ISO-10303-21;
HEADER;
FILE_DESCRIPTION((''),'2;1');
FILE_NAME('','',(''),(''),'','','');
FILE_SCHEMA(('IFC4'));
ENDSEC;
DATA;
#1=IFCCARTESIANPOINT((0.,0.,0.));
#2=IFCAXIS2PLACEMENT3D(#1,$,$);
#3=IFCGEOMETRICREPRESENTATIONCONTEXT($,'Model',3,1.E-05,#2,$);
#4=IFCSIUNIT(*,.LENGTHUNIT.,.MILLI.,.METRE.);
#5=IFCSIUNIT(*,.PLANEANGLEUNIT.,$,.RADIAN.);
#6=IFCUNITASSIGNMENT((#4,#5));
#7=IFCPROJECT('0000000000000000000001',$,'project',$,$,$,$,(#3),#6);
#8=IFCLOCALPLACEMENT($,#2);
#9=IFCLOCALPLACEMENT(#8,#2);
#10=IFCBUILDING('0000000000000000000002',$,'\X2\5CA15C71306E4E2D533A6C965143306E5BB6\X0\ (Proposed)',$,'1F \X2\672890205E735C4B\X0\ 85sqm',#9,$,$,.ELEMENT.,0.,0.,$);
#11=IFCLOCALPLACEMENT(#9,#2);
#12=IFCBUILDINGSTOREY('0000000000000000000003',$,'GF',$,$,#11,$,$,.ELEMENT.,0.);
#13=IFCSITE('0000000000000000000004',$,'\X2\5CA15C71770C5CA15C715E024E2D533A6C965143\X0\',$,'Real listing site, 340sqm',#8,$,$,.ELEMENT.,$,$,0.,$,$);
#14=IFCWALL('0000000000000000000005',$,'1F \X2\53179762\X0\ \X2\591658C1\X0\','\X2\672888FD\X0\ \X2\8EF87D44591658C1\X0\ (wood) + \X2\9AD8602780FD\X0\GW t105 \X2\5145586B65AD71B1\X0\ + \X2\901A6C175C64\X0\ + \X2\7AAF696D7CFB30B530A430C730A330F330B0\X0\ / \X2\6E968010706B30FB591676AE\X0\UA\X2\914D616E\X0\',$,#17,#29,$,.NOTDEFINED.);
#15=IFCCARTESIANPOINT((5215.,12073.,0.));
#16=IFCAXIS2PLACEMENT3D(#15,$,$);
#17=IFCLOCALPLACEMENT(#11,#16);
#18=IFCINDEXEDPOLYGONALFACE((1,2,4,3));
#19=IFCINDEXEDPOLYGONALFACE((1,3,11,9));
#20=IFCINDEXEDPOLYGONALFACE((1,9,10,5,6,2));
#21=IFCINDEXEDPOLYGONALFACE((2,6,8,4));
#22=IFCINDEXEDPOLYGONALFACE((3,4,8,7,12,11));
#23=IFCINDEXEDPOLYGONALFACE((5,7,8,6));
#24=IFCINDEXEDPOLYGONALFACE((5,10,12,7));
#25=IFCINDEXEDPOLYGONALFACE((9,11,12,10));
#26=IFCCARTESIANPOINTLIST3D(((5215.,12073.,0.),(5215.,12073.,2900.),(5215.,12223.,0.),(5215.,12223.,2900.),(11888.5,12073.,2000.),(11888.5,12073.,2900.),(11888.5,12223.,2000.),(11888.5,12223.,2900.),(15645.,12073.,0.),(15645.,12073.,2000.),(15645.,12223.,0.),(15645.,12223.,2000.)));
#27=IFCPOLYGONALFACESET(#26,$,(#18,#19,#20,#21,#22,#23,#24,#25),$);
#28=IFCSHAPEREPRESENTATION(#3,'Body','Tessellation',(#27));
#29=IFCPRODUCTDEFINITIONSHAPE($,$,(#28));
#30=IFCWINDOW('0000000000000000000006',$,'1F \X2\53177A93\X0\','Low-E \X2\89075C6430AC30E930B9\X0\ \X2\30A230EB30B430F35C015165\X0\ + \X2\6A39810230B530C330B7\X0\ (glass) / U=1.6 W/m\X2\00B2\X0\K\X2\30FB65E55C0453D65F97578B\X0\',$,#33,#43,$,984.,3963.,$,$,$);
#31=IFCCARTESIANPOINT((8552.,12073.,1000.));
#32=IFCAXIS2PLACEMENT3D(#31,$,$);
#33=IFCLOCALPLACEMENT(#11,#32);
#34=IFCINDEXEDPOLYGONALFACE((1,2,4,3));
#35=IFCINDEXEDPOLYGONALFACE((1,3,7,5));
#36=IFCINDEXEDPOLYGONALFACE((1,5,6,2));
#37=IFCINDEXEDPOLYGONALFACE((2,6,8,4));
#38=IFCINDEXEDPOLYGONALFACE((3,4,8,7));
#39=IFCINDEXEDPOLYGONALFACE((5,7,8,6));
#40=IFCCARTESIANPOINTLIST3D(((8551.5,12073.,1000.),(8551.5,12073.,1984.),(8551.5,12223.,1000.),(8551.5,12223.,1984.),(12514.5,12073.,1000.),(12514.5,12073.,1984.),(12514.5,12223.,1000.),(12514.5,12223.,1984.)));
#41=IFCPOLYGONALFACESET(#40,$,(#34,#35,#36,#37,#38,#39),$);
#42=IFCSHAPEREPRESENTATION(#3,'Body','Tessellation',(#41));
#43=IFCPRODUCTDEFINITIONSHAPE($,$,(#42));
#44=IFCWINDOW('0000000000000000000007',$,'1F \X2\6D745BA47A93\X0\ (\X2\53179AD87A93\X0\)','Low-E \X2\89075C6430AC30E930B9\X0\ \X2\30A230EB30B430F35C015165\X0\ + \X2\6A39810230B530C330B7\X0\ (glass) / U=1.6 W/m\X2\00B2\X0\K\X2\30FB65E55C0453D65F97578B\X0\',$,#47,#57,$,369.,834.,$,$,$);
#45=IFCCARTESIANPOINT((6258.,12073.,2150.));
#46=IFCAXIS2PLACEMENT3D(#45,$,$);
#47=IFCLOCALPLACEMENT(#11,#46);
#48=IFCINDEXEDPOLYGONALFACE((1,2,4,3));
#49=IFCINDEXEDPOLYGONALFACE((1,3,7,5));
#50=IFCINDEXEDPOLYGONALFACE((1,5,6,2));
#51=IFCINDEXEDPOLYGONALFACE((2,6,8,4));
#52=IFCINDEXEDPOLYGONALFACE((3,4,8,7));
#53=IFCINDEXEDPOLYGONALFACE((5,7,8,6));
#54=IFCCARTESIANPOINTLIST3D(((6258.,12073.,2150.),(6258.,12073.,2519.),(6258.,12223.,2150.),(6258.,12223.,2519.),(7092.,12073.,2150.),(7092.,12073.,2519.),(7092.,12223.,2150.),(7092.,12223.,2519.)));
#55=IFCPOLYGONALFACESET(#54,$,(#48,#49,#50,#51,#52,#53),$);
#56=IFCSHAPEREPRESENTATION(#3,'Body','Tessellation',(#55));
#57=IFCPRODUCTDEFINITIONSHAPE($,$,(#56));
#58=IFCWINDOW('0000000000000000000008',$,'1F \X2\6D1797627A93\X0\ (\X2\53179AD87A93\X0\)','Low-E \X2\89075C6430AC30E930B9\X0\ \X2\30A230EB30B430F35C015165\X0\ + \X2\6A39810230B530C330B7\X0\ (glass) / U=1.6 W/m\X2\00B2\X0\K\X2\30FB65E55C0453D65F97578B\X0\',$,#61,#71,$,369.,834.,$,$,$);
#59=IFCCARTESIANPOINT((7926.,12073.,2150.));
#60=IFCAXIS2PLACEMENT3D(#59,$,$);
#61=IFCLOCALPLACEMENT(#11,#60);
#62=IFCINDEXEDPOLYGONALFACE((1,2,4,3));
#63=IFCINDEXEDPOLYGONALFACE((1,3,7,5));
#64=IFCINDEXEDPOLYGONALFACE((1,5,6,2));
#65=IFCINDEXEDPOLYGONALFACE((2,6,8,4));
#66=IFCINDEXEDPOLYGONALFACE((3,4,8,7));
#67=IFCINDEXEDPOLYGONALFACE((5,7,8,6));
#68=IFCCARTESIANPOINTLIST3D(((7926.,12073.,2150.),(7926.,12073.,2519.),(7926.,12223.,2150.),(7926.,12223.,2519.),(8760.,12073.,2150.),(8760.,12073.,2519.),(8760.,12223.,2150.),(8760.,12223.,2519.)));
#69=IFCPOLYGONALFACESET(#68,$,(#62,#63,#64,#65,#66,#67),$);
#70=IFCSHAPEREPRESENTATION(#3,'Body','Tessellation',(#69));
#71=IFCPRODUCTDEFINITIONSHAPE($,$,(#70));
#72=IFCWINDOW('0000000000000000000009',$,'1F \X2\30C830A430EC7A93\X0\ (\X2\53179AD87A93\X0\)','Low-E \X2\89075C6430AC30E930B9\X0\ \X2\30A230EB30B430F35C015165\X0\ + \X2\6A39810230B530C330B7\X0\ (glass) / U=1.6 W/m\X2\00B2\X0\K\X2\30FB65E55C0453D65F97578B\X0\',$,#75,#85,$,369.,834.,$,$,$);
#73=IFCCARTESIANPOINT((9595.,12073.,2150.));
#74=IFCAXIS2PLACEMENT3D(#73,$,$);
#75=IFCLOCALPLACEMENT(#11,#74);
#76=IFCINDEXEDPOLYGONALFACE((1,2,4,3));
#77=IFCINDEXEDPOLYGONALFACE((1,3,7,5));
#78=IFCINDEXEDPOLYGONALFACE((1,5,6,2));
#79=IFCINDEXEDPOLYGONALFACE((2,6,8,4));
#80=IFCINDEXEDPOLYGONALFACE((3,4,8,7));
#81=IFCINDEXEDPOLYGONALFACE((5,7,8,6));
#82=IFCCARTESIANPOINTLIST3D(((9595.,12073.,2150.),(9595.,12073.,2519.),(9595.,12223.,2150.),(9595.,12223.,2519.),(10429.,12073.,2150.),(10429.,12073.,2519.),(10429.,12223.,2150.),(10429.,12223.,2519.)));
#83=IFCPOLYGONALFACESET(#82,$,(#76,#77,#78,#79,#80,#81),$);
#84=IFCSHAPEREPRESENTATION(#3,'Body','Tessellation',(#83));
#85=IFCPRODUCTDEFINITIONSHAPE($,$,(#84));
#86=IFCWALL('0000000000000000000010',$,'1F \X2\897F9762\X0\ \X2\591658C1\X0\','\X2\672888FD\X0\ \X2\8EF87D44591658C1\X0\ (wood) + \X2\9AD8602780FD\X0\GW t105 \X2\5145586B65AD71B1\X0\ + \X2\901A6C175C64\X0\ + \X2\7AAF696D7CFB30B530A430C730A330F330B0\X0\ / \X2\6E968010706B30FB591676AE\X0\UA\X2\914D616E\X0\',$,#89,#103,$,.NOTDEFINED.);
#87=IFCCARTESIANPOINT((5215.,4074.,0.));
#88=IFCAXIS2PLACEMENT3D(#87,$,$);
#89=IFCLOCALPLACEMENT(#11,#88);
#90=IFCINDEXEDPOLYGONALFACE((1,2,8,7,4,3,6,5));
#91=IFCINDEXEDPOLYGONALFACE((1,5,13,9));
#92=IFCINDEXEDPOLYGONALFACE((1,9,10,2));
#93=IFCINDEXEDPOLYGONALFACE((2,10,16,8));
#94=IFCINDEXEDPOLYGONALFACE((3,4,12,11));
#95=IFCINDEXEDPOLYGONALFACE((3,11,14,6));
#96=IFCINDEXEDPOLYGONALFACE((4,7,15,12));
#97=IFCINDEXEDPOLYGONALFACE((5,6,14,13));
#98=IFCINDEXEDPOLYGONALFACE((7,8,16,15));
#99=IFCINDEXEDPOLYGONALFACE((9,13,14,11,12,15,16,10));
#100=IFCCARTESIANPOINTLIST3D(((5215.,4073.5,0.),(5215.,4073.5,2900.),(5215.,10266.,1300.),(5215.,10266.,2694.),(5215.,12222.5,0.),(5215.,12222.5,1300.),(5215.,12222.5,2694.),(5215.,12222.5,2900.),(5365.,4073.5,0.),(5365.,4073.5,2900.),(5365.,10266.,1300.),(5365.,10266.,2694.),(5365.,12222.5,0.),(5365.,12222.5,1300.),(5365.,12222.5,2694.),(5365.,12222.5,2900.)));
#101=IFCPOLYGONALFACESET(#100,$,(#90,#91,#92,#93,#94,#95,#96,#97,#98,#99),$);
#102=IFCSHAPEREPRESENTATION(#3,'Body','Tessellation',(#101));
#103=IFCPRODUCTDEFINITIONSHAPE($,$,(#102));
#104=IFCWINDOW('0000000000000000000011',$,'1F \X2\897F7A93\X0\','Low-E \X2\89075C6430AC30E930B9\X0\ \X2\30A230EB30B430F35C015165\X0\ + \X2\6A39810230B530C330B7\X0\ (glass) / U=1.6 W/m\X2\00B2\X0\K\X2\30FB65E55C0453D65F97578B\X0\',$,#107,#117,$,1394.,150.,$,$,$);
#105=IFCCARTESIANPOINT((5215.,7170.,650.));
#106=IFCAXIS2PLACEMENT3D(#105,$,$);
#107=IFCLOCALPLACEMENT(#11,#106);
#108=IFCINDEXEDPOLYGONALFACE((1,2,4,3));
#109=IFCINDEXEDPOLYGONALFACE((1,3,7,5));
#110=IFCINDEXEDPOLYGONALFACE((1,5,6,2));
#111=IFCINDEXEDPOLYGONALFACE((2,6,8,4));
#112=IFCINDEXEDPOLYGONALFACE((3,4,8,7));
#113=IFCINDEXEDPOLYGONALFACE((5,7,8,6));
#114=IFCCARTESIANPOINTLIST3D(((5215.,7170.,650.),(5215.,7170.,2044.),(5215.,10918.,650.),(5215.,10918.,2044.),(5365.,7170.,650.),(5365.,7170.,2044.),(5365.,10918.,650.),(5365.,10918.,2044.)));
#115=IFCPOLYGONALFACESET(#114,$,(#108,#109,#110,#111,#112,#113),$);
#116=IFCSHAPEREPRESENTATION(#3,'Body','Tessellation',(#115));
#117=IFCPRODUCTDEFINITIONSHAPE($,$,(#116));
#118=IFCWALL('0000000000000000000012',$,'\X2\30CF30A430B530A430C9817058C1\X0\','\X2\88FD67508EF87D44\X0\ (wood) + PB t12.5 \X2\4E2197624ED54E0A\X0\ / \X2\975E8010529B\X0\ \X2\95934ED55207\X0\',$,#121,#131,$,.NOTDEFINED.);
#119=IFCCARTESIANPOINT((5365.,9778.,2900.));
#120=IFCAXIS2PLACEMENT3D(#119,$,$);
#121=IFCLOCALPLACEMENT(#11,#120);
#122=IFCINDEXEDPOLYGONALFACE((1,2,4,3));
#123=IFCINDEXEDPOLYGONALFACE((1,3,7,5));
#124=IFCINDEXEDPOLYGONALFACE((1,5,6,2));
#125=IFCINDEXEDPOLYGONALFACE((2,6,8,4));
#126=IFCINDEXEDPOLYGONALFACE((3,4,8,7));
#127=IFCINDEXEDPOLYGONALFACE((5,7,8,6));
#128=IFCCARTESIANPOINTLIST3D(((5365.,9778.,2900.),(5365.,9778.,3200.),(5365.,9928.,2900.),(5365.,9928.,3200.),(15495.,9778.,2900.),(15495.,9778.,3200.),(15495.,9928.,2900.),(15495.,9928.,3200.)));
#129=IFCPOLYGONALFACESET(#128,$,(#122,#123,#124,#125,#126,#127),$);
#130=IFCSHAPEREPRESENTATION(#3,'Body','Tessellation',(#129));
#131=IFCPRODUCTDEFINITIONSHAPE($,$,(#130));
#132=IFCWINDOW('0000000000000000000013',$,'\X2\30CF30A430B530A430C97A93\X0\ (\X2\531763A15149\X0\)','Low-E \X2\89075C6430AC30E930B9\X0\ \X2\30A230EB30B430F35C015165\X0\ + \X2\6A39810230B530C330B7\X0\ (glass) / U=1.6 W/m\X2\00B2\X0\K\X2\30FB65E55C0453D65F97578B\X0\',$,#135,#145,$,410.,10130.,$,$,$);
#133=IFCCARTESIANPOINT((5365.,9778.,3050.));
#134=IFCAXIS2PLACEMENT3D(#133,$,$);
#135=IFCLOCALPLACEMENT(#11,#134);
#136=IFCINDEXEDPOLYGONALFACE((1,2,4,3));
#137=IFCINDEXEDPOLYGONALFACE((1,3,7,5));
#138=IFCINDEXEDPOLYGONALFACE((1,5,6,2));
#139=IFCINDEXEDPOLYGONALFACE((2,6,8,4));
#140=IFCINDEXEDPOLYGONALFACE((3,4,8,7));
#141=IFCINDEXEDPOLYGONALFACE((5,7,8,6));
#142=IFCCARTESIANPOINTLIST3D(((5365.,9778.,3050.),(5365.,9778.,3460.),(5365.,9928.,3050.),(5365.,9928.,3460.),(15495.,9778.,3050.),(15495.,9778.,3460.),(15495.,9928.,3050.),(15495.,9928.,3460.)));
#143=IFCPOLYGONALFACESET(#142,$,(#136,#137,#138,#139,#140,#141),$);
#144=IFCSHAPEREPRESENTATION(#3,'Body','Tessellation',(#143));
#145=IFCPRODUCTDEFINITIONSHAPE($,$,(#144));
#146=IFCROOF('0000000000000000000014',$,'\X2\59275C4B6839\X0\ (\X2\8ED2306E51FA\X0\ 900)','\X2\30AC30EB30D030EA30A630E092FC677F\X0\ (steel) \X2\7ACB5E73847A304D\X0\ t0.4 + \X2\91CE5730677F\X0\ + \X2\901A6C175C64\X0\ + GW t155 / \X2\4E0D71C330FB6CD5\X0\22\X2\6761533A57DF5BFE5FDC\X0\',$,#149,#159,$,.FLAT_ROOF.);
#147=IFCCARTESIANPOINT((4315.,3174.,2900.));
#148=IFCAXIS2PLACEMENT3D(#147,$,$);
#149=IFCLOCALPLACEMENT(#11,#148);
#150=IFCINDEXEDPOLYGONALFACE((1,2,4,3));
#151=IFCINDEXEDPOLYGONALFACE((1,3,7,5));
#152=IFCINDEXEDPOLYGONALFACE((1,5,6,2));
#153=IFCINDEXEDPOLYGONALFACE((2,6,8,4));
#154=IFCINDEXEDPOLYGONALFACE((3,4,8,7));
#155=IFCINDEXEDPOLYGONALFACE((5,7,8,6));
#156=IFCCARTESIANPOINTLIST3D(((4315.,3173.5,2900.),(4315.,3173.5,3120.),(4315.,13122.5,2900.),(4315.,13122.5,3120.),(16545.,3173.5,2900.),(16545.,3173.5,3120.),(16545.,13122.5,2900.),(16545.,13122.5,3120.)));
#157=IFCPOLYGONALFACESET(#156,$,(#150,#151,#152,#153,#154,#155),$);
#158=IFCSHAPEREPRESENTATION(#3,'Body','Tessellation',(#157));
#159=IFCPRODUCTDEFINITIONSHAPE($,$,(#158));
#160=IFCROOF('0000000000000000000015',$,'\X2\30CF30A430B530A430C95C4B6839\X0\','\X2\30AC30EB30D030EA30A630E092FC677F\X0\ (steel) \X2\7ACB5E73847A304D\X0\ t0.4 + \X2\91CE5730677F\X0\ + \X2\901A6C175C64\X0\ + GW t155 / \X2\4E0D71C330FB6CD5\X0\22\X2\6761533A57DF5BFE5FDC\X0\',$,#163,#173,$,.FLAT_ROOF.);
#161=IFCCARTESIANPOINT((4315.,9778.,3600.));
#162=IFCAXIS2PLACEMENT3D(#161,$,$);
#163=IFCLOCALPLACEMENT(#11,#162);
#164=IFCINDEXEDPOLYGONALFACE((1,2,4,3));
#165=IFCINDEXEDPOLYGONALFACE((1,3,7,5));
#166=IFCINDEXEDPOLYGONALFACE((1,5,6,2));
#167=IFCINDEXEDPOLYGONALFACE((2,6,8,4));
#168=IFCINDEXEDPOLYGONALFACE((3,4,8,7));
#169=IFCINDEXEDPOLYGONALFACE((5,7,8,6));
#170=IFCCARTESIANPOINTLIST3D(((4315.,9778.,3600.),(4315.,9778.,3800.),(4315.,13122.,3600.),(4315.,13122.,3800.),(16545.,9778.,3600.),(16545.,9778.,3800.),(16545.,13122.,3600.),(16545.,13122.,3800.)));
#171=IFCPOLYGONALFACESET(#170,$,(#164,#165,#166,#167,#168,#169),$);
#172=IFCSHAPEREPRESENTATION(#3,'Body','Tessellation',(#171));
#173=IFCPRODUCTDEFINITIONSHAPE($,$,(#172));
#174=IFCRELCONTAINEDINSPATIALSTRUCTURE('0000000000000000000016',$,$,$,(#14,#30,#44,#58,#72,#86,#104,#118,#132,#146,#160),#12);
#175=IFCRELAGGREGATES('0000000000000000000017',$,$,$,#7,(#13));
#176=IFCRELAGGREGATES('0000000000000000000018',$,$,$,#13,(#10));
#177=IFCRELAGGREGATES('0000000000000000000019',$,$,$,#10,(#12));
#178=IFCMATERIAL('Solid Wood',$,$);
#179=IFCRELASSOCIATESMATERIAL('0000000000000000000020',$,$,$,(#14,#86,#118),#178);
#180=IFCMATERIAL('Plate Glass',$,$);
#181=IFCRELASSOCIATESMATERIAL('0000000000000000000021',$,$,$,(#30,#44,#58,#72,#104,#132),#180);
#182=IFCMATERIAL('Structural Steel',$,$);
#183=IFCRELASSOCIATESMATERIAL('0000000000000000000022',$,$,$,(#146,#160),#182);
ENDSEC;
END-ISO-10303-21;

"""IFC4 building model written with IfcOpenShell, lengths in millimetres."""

from ifc_helpers import new_model, si_unit, frame, frame_2d, origin, place, context, project, spatial, rectangle, extrude, material, element, fill, save


model = new_model("IFC4")

# Units and contexts
model_context = context("Model", 3, precision=1e-05, world=origin())
ifc_project = project(units=[si_unit("LENGTHUNIT", "METRE", prefix="MILLI"), si_unit("PLANEANGLEUNIT", "RADIAN")], contexts=[model_context])

# Site, building, storey
site_placement = place(None, origin())
site = spatial("IfcSite", under=ifc_project, at=site_placement, Name="岡山県岡山市中区沖元", ObjectType="Real listing site, 340sqm", CompositionType="ELEMENT", RefElevation=0.0)
building_placement = place(site_placement, origin())
building = spatial("IfcBuilding", under=site, at=building_placement, Name="岡山の中区沖元の家 (Proposed)", ObjectType="1F 木造平屋 85sqm", CompositionType="ELEMENT", ElevationOfRefHeight=0.0, ElevationOfTerrain=0.0)
storey_placement = place(building_placement, origin())
storey = spatial("IfcBuildingStorey", under=building, at=storey_placement, Name="GF", CompositionType="ELEMENT", Elevation=0.0)

# Shared definitions
ifc_material_1 = material(Name="Solid Wood")

# Shared definitions
ifc_material_2 = material(Name="Plate Glass")

# Wall, openings, windows
wall_1_placement = place(storey_placement, frame((5215.0, 12073.0, 0.0)))
wall_1 = element("IfcWall", 1, at=wall_1_placement, inside=storey, material=ifc_material_1, Name="1F 北面 外壁", Description="木製 軸組外壁 (wood) + 高性能GW t105 充填断熱 + 通気層 + 窯業系サイディング / 準耐火・外皮UA配慮", PredefinedType="NOTDEFINED", context=model_context, shape_type="SweptSolid", body=[
    extrude(rectangle(XDim=10430.0, YDim=150.0, at=frame_2d((5215.0, 75.0))), frame((5215.0, 12073.0, 0.0)), (0.0, 0.0, 1.0), 2900.0),
])
opening_1_placement = place(storey_placement, frame((8552.0, 12073.0, 1000.0)))
opening_1 = element("IfcOpeningElement", 2, at=opening_1_placement, cuts=wall_1, PredefinedType="NOTDEFINED", context=model_context, shape_type="SweptSolid", body=[
    extrude(rectangle(XDim=3963.0, YDim=150.0, at=frame_2d((1981.0, 75.0))), frame((8552.0, 12073.0, 1000.0)), (0.0, 0.0, 1.0), 984.0),
])
opening_2_placement = place(storey_placement, frame((6258.0, 12073.0, 2150.0)))
opening_2 = element("IfcOpeningElement", 3, at=opening_2_placement, cuts=wall_1, PredefinedType="NOTDEFINED", context=model_context, shape_type="SweptSolid", body=[
    extrude(rectangle(XDim=834.0, YDim=150.0, at=frame_2d((417.0, 75.0))), frame((6258.0, 12073.0, 2150.0)), (0.0, 0.0, 1.0), 369.0),
])
opening_3_placement = place(storey_placement, frame((7926.0, 12073.0, 2150.0)))
opening_3 = element("IfcOpeningElement", 4, at=opening_3_placement, cuts=wall_1, PredefinedType="NOTDEFINED", context=model_context, shape_type="SweptSolid", body=[
    extrude(rectangle(XDim=834.0, YDim=150.0, at=frame_2d((417.0, 75.0))), frame((7926.0, 12073.0, 2150.0)), (0.0, 0.0, 1.0), 369.0),
])
opening_4_placement = place(storey_placement, frame((9595.0, 12073.0, 2150.0)))
opening_4 = element("IfcOpeningElement", 5, at=opening_4_placement, cuts=wall_1, PredefinedType="NOTDEFINED", context=model_context, shape_type="SweptSolid", body=[
    extrude(rectangle(XDim=834.0, YDim=150.0, at=frame_2d((417.0, 75.0))), frame((9595.0, 12073.0, 2150.0)), (0.0, 0.0, 1.0), 369.0),
])
window_1_placement = place(storey_placement, frame((8552.0, 12073.0, 1000.0)))
window_1 = element("IfcWindow", 6, at=window_1_placement, inside=storey, material=ifc_material_2, Name="1F 北窓", Description="Low-E 複層ガラス アルゴン封入 + 樹脂サッシ (glass) / U=1.6 W/m²K・日射取得型", OverallHeight=984.0, OverallWidth=3963.0, context=model_context, shape_type="SweptSolid", body=[
    extrude(rectangle(XDim=3963.0, YDim=150.0, at=frame_2d((1981.0, 75.0))), frame((8552.0, 12073.0, 1000.0)), (0.0, 0.0, 1.0), 984.0),
])
fill(opening_1, window_1)
window_2_placement = place(storey_placement, frame((6258.0, 12073.0, 2150.0)))
window_2 = element("IfcWindow", 7, at=window_2_placement, inside=storey, material=ifc_material_2, Name="1F 浴室窓 (北高窓)", Description="Low-E 複層ガラス アルゴン封入 + 樹脂サッシ (glass) / U=1.6 W/m²K・日射取得型", OverallHeight=369.0, OverallWidth=834.0, context=model_context, shape_type="SweptSolid", body=[
    extrude(rectangle(XDim=834.0, YDim=150.0, at=frame_2d((417.0, 75.0))), frame((6258.0, 12073.0, 2150.0)), (0.0, 0.0, 1.0), 369.0),
])
fill(opening_2, window_2)
window_3_placement = place(storey_placement, frame((7926.0, 12073.0, 2150.0)))
window_3 = element("IfcWindow", 8, at=window_3_placement, inside=storey, material=ifc_material_2, Name="1F 洗面窓 (北高窓)", Description="Low-E 複層ガラス アルゴン封入 + 樹脂サッシ (glass) / U=1.6 W/m²K・日射取得型", OverallHeight=369.0, OverallWidth=834.0, context=model_context, shape_type="SweptSolid", body=[
    extrude(rectangle(XDim=834.0, YDim=150.0, at=frame_2d((417.0, 75.0))), frame((7926.0, 12073.0, 2150.0)), (0.0, 0.0, 1.0), 369.0),
])
fill(opening_3, window_3)
window_4_placement = place(storey_placement, frame((9595.0, 12073.0, 2150.0)))
window_4 = element("IfcWindow", 9, at=window_4_placement, inside=storey, material=ifc_material_2, Name="1F トイレ窓 (北高窓)", Description="Low-E 複層ガラス アルゴン封入 + 樹脂サッシ (glass) / U=1.6 W/m²K・日射取得型", OverallHeight=369.0, OverallWidth=834.0, context=model_context, shape_type="SweptSolid", body=[
    extrude(rectangle(XDim=834.0, YDim=150.0, at=frame_2d((417.0, 75.0))), frame((9595.0, 12073.0, 2150.0)), (0.0, 0.0, 1.0), 369.0),
])
fill(opening_4, window_4)

# Wall, opening, window
wall_2_placement = place(storey_placement, frame((5215.0, 4074.0, 0.0)))
wall_2 = element("IfcWall", 10, at=wall_2_placement, inside=storey, material=ifc_material_1, Name="1F 西面 外壁", Description="木製 軸組外壁 (wood) + 高性能GW t105 充填断熱 + 通気層 + 窯業系サイディング / 準耐火・外皮UA配慮", PredefinedType="NOTDEFINED", context=model_context, shape_type="SweptSolid", body=[
    extrude(rectangle(XDim=150.0, YDim=8149.0, at=frame_2d((75.0, 4074.0))), frame((5215.0, 4074.0, 0.0)), (0.0, 0.0, 1.0), 2900.0),
])
opening_5_placement = place(storey_placement, frame((5215.0, 7170.0, 650.0)))
opening_5 = element("IfcOpeningElement", 11, at=opening_5_placement, cuts=wall_2, PredefinedType="NOTDEFINED", context=model_context, shape_type="SweptSolid", body=[
    extrude(rectangle(XDim=150.0, YDim=3748.0, at=frame_2d((75.0, 1874.0))), frame((5215.0, 7170.0, 650.0)), (0.0, 0.0, 1.0), 1394.0),
])
window_5_placement = place(storey_placement, frame((5215.0, 7170.0, 650.0)))
window_5 = element("IfcWindow", 12, at=window_5_placement, inside=storey, material=ifc_material_2, Name="1F 西窓", Description="Low-E 複層ガラス アルゴン封入 + 樹脂サッシ (glass) / U=1.6 W/m²K・日射取得型", OverallHeight=1394.0, OverallWidth=150.0, context=model_context, shape_type="SweptSolid", body=[
    extrude(rectangle(XDim=150.0, YDim=3748.0, at=frame_2d((75.0, 1874.0))), frame((5215.0, 7170.0, 650.0)), (0.0, 0.0, 1.0), 1394.0),
])
fill(opening_5, window_5)

# Wall, opening, window
wall_3_placement = place(storey_placement, frame((5365.0, 9778.0, 2900.0)))
wall_3 = element("IfcWall", 13, at=wall_3_placement, inside=storey, material=ifc_material_1, Name="ハイサイド腰壁", Description="製材軸組 (wood) + PB t12.5 両面仕上 / 非耐力 間仕切", PredefinedType="NOTDEFINED", context=model_context, shape_type="SweptSolid", body=[
    extrude(rectangle(XDim=10130.0, YDim=150.0, at=frame_2d((5065.0, 75.0))), frame((5365.0, 9778.0, 2900.0)), (0.0, 0.0, 1.0), 700.0),
])
opening_6_placement = place(storey_placement, frame((5365.0, 9778.0, 3050.0)))
opening_6 = element("IfcOpeningElement", 14, at=opening_6_placement, cuts=wall_3, PredefinedType="NOTDEFINED", context=model_context, shape_type="SweptSolid", body=[
    extrude(rectangle(XDim=10130.0, YDim=150.0, at=frame_2d((5065.0, 75.0))), frame((5365.0, 9778.0, 3050.0)), (0.0, 0.0, 1.0), 410.0),
])
window_6_placement = place(storey_placement, frame((5365.0, 9778.0, 3050.0)))
window_6 = element("IfcWindow", 15, at=window_6_placement, inside=storey, material=ifc_material_2, Name="ハイサイド窓 (北採光)", Description="Low-E 複層ガラス アルゴン封入 + 樹脂サッシ (glass) / U=1.6 W/m²K・日射取得型", OverallHeight=410.0, OverallWidth=10130.0, context=model_context, shape_type="SweptSolid", body=[
    extrude(rectangle(XDim=10130.0, YDim=150.0, at=frame_2d((5065.0, 75.0))), frame((5365.0, 9778.0, 3050.0)), (0.0, 0.0, 1.0), 410.0),
])
fill(opening_6, window_6)

# Roofs
ifc_material_3 = material(Name="Structural Steel")
roof_1_placement = place(storey_placement, frame((4315.0, 3174.0, 2900.0)))
element("IfcRoof", 16, at=roof_1_placement, inside=storey, material=ifc_material_3, Name="大屋根 (軒の出 900)", Description="ガルバリウム鋼板 (steel) 立平葺き t0.4 + 野地板 + 通気層 + GW t155 / 不燃・法22条区域対応", PredefinedType="FLAT_ROOF", context=model_context, shape_type="SweptSolid", body=[
    extrude(rectangle(XDim=12230.0, YDim=9949.0, at=frame_2d((6115.0, 4974.0))), frame((4315.0, 3174.0, 2900.0)), (0.0, 0.0, 1.0), 220.0),
])
roof_2_placement = place(storey_placement, frame((4315.0, 9778.0, 3600.0)))
element("IfcRoof", 17, at=roof_2_placement, inside=storey, material=ifc_material_3, Name="ハイサイド屋根", Description="ガルバリウム鋼板 (steel) 立平葺き t0.4 + 野地板 + 通気層 + GW t155 / 不燃・法22条区域対応", PredefinedType="FLAT_ROOF", context=model_context, shape_type="SweptSolid", body=[
    extrude(rectangle(XDim=12230.0, YDim=3344.0, at=frame_2d((6115.0, 1672.0))), frame((4315.0, 9778.0, 3600.0)), (0.0, 0.0, 1.0), 200.0),
])

save(model, "model.ifc")
